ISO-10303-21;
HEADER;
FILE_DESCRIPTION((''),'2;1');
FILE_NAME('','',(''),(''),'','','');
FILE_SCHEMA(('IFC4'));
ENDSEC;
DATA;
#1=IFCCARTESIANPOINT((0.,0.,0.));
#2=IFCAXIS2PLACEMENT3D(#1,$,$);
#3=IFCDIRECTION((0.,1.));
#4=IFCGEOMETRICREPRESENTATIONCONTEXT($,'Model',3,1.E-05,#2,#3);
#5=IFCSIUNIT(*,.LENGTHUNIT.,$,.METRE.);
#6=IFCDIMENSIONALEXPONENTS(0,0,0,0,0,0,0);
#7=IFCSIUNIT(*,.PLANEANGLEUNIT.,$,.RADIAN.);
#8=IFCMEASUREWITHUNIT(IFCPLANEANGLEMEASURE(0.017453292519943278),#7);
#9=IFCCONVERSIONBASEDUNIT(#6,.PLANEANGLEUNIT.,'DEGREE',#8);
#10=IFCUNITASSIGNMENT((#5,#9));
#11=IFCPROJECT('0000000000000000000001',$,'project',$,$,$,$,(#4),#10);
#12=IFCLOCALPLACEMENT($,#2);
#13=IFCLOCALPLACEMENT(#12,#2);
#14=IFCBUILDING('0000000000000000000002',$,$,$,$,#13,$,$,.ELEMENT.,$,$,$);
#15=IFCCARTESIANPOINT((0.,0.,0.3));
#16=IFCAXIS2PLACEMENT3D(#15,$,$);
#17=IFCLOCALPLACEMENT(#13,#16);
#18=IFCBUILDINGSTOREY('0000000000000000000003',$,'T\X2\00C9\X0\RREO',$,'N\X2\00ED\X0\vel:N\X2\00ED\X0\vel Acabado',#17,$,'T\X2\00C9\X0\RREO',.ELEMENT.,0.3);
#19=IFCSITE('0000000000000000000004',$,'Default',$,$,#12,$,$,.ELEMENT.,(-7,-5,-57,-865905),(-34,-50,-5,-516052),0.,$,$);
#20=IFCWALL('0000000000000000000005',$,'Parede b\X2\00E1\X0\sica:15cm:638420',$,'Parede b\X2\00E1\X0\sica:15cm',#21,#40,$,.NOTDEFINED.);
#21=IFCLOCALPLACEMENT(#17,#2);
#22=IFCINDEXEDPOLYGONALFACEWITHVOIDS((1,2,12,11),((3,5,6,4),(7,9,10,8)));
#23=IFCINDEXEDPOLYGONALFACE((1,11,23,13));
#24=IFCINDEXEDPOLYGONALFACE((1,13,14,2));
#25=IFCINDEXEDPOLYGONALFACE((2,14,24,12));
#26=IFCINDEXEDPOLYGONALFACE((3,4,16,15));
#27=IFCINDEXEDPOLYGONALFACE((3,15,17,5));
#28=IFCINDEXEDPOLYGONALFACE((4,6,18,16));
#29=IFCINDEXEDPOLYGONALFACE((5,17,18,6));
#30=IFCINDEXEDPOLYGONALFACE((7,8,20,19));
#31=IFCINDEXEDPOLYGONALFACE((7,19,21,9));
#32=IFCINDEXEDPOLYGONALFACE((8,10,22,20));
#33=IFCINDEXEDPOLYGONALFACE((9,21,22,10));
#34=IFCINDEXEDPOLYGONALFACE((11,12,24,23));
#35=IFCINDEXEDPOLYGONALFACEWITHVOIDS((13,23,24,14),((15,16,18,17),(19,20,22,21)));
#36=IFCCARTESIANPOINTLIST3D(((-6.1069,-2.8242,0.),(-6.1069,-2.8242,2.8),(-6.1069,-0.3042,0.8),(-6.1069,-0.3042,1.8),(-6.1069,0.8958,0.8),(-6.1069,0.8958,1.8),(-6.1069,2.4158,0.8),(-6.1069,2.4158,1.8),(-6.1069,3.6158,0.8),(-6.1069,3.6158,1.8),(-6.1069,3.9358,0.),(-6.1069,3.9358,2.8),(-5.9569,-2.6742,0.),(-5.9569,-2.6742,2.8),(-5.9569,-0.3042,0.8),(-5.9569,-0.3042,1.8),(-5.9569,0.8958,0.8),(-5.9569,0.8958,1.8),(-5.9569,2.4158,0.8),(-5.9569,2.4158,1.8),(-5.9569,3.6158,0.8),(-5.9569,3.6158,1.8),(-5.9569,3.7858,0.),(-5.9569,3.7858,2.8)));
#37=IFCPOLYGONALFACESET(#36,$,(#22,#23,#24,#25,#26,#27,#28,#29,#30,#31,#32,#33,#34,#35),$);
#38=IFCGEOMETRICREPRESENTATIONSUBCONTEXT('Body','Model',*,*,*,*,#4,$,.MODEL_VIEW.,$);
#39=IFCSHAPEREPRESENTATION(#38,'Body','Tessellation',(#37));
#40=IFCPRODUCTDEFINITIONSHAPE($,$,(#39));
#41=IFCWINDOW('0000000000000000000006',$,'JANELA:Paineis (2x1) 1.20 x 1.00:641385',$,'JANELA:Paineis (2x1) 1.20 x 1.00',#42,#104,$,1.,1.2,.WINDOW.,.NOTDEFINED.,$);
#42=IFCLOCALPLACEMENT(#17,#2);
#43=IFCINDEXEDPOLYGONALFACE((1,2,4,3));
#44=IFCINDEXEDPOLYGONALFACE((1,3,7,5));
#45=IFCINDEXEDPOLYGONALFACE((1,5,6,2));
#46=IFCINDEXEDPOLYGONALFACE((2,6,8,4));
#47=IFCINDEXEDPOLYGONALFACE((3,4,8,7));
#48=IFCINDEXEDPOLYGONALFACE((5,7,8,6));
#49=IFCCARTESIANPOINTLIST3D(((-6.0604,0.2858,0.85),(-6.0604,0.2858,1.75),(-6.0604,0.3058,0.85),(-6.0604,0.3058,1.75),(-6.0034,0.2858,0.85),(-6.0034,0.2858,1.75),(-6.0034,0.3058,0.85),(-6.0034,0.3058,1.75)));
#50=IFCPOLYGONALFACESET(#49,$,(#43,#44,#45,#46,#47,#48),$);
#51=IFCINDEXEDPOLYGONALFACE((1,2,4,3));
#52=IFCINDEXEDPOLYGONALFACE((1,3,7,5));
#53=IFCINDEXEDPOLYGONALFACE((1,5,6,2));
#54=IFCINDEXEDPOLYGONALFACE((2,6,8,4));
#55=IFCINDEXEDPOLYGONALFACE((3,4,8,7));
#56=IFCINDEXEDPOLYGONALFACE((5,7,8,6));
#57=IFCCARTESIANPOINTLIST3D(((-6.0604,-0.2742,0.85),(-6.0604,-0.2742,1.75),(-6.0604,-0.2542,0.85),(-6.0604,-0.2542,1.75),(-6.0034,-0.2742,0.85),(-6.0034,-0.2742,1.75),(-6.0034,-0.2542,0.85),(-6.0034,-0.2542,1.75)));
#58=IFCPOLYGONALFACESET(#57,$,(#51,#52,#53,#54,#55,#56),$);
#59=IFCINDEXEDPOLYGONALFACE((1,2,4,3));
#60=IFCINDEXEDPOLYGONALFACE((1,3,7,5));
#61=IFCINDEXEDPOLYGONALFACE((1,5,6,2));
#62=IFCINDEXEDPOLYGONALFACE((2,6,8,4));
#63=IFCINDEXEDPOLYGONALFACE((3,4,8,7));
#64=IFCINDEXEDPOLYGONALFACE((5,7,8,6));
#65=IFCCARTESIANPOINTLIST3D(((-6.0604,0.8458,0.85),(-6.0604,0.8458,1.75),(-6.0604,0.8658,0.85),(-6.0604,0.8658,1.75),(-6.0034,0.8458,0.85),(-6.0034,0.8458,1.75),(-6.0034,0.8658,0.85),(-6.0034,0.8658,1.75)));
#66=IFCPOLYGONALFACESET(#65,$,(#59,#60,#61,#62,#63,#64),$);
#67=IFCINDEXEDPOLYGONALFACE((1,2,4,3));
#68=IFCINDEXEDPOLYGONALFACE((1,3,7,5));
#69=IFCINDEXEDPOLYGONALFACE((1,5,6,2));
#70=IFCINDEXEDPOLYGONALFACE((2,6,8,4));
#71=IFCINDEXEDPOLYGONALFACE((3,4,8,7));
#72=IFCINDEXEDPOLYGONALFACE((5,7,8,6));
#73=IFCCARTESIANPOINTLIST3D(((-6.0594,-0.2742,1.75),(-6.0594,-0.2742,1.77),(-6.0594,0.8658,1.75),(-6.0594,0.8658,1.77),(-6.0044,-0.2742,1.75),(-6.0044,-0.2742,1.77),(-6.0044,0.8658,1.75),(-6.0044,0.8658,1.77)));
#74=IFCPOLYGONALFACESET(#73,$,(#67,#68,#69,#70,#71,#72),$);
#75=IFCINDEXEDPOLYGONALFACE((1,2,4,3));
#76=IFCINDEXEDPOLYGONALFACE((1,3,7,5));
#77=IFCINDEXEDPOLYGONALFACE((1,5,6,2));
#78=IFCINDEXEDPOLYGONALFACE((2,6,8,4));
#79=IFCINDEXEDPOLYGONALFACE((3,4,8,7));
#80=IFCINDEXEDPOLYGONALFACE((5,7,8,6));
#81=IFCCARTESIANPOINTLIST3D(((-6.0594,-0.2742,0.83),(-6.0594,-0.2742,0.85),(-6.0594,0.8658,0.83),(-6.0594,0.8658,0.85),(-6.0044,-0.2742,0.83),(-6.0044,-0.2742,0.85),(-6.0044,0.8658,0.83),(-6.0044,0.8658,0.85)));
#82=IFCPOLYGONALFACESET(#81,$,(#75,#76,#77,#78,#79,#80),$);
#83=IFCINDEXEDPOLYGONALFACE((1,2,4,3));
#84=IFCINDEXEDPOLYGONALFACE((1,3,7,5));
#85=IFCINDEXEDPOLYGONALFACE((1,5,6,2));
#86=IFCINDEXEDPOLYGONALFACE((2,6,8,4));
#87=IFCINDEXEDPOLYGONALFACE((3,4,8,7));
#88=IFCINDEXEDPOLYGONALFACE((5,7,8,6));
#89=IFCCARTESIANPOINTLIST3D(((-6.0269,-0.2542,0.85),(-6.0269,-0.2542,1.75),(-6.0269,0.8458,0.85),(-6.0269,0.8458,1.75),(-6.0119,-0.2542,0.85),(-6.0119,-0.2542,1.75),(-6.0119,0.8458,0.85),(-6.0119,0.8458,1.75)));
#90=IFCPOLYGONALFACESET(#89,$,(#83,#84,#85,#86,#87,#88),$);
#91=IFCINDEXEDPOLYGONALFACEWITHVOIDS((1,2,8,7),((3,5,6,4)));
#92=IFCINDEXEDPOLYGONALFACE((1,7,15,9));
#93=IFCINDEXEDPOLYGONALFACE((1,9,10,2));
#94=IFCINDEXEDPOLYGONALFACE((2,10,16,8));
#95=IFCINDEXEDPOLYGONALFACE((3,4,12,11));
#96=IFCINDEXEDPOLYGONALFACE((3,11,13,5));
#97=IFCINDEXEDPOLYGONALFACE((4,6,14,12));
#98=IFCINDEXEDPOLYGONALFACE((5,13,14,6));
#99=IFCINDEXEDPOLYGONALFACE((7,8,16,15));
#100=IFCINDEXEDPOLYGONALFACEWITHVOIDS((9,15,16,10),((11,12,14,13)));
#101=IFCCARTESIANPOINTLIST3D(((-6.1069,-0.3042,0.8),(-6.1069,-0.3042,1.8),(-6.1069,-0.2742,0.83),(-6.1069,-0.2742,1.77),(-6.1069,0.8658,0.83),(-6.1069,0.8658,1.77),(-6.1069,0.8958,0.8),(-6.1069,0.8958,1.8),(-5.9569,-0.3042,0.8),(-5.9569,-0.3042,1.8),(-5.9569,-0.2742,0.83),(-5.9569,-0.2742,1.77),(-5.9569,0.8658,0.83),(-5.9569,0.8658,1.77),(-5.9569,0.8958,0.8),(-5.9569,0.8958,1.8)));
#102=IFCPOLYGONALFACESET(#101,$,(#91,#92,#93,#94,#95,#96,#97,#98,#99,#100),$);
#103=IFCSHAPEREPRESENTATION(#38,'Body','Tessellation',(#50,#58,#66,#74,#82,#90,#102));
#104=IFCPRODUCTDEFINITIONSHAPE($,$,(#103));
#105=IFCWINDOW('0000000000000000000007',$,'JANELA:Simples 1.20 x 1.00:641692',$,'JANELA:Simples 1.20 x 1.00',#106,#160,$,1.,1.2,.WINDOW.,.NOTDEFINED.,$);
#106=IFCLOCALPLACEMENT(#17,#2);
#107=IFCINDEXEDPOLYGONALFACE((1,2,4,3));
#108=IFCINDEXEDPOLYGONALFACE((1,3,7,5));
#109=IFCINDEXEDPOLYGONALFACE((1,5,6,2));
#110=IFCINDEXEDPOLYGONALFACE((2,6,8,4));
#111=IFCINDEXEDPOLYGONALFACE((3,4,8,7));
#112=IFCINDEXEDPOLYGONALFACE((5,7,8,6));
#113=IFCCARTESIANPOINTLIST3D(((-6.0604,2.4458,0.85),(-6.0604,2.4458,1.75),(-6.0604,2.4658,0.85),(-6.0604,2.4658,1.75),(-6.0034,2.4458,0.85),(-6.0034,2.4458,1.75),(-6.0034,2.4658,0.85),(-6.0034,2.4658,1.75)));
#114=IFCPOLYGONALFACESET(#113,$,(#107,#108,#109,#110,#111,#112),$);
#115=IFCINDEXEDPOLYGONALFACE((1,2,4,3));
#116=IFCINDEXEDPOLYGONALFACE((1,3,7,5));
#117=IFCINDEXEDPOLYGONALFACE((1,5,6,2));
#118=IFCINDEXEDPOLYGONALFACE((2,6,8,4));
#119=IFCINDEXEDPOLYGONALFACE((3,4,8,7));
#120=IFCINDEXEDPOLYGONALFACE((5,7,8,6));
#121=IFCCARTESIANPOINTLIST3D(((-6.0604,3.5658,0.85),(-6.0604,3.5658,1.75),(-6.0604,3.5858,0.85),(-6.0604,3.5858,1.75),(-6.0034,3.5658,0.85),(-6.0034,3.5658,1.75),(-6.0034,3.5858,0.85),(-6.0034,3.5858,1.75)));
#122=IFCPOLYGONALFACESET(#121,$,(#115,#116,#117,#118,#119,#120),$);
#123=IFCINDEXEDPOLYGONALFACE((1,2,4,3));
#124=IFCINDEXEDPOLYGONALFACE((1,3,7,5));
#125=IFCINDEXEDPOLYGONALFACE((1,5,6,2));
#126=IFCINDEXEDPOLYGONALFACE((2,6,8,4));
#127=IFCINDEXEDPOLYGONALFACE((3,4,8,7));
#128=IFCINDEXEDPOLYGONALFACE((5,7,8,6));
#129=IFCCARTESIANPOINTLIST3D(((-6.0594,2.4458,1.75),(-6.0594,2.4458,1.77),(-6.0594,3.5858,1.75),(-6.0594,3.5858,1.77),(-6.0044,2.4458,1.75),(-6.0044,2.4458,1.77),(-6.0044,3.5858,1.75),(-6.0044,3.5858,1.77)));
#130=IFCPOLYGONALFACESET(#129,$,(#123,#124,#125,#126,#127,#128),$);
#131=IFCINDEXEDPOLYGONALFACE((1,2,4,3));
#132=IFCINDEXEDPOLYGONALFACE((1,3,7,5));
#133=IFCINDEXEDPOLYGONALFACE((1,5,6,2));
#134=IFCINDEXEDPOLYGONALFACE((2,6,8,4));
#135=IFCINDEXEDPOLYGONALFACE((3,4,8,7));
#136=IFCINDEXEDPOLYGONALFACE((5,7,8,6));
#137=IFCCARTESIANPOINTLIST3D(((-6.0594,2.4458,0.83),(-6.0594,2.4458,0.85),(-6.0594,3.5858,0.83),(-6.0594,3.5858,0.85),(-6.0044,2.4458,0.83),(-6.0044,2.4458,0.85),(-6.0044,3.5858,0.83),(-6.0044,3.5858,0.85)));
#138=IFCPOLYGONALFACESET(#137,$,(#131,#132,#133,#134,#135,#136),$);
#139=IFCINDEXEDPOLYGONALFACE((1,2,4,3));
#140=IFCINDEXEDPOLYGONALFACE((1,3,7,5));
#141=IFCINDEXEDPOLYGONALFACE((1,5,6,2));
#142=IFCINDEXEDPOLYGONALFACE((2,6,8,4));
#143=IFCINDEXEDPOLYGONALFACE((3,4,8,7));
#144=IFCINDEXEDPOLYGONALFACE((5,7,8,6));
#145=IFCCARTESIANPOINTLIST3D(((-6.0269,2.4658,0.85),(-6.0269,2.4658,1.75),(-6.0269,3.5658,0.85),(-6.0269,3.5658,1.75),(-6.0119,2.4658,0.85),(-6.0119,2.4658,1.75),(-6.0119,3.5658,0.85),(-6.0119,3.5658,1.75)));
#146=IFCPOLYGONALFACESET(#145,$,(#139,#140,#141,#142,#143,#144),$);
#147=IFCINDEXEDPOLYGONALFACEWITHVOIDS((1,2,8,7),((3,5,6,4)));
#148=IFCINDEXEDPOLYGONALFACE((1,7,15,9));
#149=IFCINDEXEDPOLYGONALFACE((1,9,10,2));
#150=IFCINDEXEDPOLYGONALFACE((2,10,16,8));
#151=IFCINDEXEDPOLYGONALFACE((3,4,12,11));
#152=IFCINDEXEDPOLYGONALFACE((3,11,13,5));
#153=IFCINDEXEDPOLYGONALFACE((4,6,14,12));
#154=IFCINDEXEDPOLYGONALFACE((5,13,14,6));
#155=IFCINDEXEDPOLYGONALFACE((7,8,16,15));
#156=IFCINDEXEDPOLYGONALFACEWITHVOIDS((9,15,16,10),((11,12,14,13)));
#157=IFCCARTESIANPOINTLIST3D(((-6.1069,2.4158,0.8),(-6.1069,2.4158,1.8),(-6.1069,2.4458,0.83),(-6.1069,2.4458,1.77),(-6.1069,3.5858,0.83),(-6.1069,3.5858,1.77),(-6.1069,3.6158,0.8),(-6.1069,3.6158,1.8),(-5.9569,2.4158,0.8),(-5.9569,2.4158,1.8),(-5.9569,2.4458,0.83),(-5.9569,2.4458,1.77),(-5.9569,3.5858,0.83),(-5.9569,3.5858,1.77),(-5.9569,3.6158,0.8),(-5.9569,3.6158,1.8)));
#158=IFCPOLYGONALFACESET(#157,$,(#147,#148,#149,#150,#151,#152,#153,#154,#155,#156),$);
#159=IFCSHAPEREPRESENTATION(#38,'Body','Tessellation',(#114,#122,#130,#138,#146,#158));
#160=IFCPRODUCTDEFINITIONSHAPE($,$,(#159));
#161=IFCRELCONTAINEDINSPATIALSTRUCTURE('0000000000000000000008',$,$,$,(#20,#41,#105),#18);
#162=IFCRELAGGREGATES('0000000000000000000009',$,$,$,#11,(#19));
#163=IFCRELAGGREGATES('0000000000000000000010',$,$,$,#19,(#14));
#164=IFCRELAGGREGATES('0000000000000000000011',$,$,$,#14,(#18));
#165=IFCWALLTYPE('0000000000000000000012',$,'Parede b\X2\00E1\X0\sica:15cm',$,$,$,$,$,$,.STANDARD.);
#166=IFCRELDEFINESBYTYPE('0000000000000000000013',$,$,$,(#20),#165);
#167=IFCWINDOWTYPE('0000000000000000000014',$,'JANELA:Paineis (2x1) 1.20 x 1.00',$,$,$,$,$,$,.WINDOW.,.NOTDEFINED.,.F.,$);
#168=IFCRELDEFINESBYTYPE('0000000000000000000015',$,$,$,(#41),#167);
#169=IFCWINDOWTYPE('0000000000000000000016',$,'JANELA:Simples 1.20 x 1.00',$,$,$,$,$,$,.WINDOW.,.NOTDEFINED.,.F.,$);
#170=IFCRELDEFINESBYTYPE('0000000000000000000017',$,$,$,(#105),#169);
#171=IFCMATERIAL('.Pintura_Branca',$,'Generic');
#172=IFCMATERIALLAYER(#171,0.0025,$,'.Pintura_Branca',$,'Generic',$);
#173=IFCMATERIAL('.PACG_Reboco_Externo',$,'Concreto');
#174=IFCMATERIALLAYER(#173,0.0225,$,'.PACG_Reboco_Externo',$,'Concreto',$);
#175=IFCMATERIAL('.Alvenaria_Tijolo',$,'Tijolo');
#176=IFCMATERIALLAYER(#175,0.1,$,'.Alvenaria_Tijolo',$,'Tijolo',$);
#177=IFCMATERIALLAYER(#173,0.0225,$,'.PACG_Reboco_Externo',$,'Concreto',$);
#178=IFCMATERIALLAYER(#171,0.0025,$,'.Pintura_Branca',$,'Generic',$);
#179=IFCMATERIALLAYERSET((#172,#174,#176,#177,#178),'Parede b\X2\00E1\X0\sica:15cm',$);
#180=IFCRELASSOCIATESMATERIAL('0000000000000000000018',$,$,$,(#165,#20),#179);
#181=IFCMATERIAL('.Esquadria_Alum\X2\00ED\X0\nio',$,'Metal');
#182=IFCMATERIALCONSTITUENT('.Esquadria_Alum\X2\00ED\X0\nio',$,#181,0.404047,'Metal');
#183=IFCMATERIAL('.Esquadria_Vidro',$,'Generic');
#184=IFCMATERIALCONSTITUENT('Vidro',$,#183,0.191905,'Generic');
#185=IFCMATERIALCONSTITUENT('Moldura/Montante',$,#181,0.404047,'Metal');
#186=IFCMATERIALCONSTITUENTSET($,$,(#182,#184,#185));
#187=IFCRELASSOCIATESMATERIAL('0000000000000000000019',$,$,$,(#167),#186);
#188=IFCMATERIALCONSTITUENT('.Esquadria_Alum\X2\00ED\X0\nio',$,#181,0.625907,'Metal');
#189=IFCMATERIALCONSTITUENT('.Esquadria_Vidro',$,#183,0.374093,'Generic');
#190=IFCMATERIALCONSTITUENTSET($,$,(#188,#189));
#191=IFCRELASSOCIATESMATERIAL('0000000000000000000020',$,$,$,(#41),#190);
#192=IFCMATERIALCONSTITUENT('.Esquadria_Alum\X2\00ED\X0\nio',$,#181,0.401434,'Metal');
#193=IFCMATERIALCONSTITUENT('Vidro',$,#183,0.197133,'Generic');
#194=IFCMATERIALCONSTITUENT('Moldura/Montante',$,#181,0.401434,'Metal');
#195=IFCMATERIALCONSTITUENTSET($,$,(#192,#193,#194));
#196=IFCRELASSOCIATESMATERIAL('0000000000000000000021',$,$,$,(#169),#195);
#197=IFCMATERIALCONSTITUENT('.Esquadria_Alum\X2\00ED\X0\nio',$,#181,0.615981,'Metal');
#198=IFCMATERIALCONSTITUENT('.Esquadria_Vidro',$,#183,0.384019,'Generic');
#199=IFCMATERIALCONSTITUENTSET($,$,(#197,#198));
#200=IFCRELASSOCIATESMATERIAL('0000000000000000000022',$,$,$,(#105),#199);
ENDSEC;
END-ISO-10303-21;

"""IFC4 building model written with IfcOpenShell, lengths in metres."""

from ifc_helpers import new_model, entity, si_unit, converted_unit, direction, frame, frame_2d, origin, origin_2d_with_axis, place, context, subcontext, project, spatial, polyline, rectangle, outline, extrude, source, transform, mapped, material, layer, layer_set, layer_usage, constituent, constituent_set, type_object, type_shapes, element, fill, save


model = new_model("IFC4")

# Units and contexts
model_context = context("Model", 3, precision=1e-05, world=origin(), true_north=direction((0.0, 1.0)))
body_context = subcontext(model_context, "Body", "Model", "MODEL_VIEW")
ifc_project = project(units=[si_unit("LENGTHUNIT", "METRE"), converted_unit("PLANEANGLEUNIT", "DEGREE", entity("IfcPlaneAngleMeasure", 0.017453292519943278), si_unit("PLANEANGLEUNIT", "RADIAN"), dimensions=[0, 0, 0, 0, 0, 0, 0])], contexts=[model_context])

# Site, building, storey
site_placement = place(None, origin())
site = spatial("IfcSite", under=ifc_project, at=site_placement, Name="Default", CompositionType="ELEMENT", RefLatitude=(-7, -5, -57, -865905), RefLongitude=(-34, -50, -5, -516052), RefElevation=0.0)
building_placement = place(site_placement, origin())
building = spatial("IfcBuilding", under=site, at=building_placement, CompositionType="ELEMENT")
storey_placement = place(building_placement, frame((0.0, 0.0, 0.3)))
storey = spatial("IfcBuildingStorey", under=building, at=storey_placement, Name="TÉRREO", ObjectType="Nível:Nível Acabado", LongName="TÉRREO", CompositionType="ELEMENT", Elevation=0.3)

# Wall, openings, windows
ifc_material_1 = material(Name=".Pintura_Branca", Category="Generic")
ifc_layer_1 = layer(ifc_material_1, 0.0025, Name=".Pintura_Branca", Category="Generic")
ifc_material_2 = material(Name=".PACG_Reboco_Externo", Category="Concreto")
ifc_layer_2 = layer(ifc_material_2, 0.0225, Name=".PACG_Reboco_Externo", Category="Concreto")
ifc_material_3 = material(Name=".Alvenaria_Tijolo", Category="Tijolo")
ifc_layer_3 = layer(ifc_material_3, 0.1, Name=".Alvenaria_Tijolo", Category="Tijolo")
ifc_layer_4 = layer(ifc_material_2, 0.0225, Name=".PACG_Reboco_Externo", Category="Concreto")
ifc_layer_5 = layer(ifc_material_1, 0.0025, Name=".Pintura_Branca", Category="Generic")
ifc_layer_set_1 = layer_set([ifc_layer_1, ifc_layer_2, ifc_layer_3, ifc_layer_4, ifc_layer_5], Name="Parede básica:15cm")
ifc_layer_usage_1 = layer_usage(ifc_layer_set_1, "AXIS2", "NEGATIVE", 0.075)
wall_type = type_object("IfcWallType", Name="Parede básica:15cm", PredefinedType="STANDARD", material=ifc_layer_set_1)
wall_1_placement = place(storey_placement, frame((-6.0319, 3.9358, 0.0), z_axis=(0.0, 0.0, 1.0), x_axis=(0.0, -1.0, 0.0)))
wall_1 = element("IfcWall", 1, at=wall_1_placement, inside=storey, type_object=wall_type, material=ifc_layer_usage_1, Name="Parede básica:15cm:638420", ObjectType="Parede básica:15cm", PredefinedType="NOTDEFINED", context=body_context, shape_type="SweptSolid", body=[
    extrude(outline(polyline([(6.76, -0.075), (6.61, 0.075), (1.84, 0.075), (1.69, 0.075), (0.15, 0.075), (0.0, -0.075), (6.76, -0.075)])), origin(), (0.0, 0.0, 1.0), 2.8),
])
opening_1_placement = place(wall_1_placement, frame((4.24, 0.075, 0.8)))
opening_1 = element("IfcOpeningElement", 2, at=opening_1_placement, cuts=wall_1, PredefinedType="OPENING", context=body_context, shape_type="SweptSolid", body=[
    extrude(rectangle(XDim=1.0, YDim=1.2, at=frame_2d((0.5, 0.6), x_axis=(1.0, 0.0))), frame((0.0, 0.0, 0.0), z_axis=(0.0, -1.0, 0.0), x_axis=(0.0, 0.0, 1.0)), (0.0, 0.0, 1.0), 0.15),
])
opening_2_placement = place(wall_1_placement, frame((1.52, 0.075, 0.8)))
opening_2 = element("IfcOpeningElement", 3, at=opening_2_placement, cuts=wall_1, PredefinedType="OPENING", context=body_context, shape_type="SweptSolid", body=[
    extrude(rectangle(XDim=1.0, YDim=1.2, at=frame_2d((0.5, 0.6), x_axis=(1.0, 0.0))), frame((0.0, 0.0, 0.0), z_axis=(0.0, -1.0, 0.0), x_axis=(0.0, 0.0, 1.0)), (0.0, 0.0, 1.0), 0.15),
])
ifc_material_4 = material(Name=".Esquadria_Alumínio", Category="Metal")
ifc_constituent_1 = constituent(ifc_material_4, Name=".Esquadria_Alumínio", Category="Metal", fraction=0.625907)
ifc_material_5 = material(Name=".Esquadria_Vidro", Category="Generic")
ifc_constituent_2 = constituent(ifc_material_5, Name=".Esquadria_Vidro", Category="Generic", fraction=0.374093)
ifc_constituent_set_1 = constituent_set(constituents=[ifc_constituent_1, ifc_constituent_2])
ifc_constituent_3 = constituent(ifc_material_4, Name=".Esquadria_Alumínio", Category="Metal", fraction=0.404047)
ifc_constituent_4 = constituent(ifc_material_5, Name="Vidro", Category="Generic", fraction=0.191905)
ifc_constituent_5 = constituent(ifc_material_4, Name="Moldura/Montante", Category="Metal", fraction=0.404047)
ifc_constituent_set_2 = constituent_set(constituents=[ifc_constituent_3, ifc_constituent_4, ifc_constituent_5])
window_type_1 = type_object("IfcWindowType", Name="JANELA:Paineis (2x1) 1.20 x 1.00", ParameterTakesPrecedence=False, PartitioningType="NOTDEFINED", PredefinedType="WINDOW", material=ifc_constituent_set_2)
shared_shape_1 = source(origin(), body_context, "Body", "SweptSolid", [
    extrude(rectangle(XDim=0.02, YDim=0.057, at=origin_2d_with_axis()), frame((0.6, 0.075, 0.05), z_axis=(0.0, 0.0, 1.0), x_axis=(-1.0, 0.0, 0.0)), (0.0, 0.0, 1.0), 0.9),
    extrude(rectangle(XDim=0.02, YDim=0.057, at=frame_2d((0.0, 0.0), x_axis=(1.0, 0.0))), frame((0.04, 0.075, 0.05), z_axis=(0.0, 0.0, 1.0), x_axis=(-1.0, 0.0, 0.0)), (0.0, 0.0, 1.0), 0.9),
    extrude(rectangle(XDim=0.02, YDim=0.057, at=frame_2d((0.0, 0.0), x_axis=(1.0, 0.0))), frame((1.16, 0.075, 0.05), z_axis=(0.0, 0.0, 1.0), x_axis=(-1.0, 0.0, 0.0)), (0.0, 0.0, 1.0), 0.9),
    extrude(rectangle(XDim=1.14, YDim=0.055, at=frame_2d((0.0, 0.0), x_axis=(1.0, 0.0))), frame((0.6, 0.075, 0.95), z_axis=(0.0, 0.0, 1.0), x_axis=(-1.0, 0.0, 0.0)), (0.0, 0.0, 1.0), 0.02),
    extrude(rectangle(XDim=1.14, YDim=0.055, at=frame_2d((0.0, 0.0), x_axis=(1.0, 0.0))), frame((0.6, 0.075, 0.03), z_axis=(0.0, 0.0, 1.0), x_axis=(-1.0, 0.0, 0.0)), (0.0, 0.0, 1.0), 0.02),
    extrude(rectangle(XDim=0.015, YDim=1.1, at=frame_2d((0.0, 0.0), x_axis=(1.0, 0.0))), frame((0.6, 0.0625, 0.05), z_axis=(0.0, 0.0, 1.0), x_axis=(0.0, 1.0, 0.0)), (0.0, 0.0, 1.0), 0.9),
    extrude(outline(polyline([(-0.6, -0.5), (0.6, -0.5), (0.6, 0.5), (-0.6, 0.5), (-0.6, -0.5)]), holes=[polyline([(0.57, -0.47), (-0.57, -0.47), (-0.57, 0.47), (0.57, 0.47), (0.57, -0.47)])]), frame((0.6, 0.0, 0.5), z_axis=(0.0, 1.0, 0.0), x_axis=(1.0, 0.0, 0.0)), (0.0, 0.0, 1.0), 0.15),
])
type_shapes(window_type_1, [shared_shape_1])
window_1_placement = place(opening_1_placement, frame((0.0, 0.0, 0.0), z_axis=(0.0, 0.0, 1.0), x_axis=(-1.0, 0.0, 0.0)))
window_1 = element("IfcWindow", 4, at=window_1_placement, inside=storey, type_object=window_type_1, material=ifc_constituent_set_1, Name="JANELA:Paineis (2x1) 1.20 x 1.00:641385", ObjectType="JANELA:Paineis (2x1) 1.20 x 1.00", OverallHeight=1.0, OverallWidth=1.2, PartitioningType="NOTDEFINED", PredefinedType="WINDOW", context=body_context, shape_type="MappedRepresentation", body=[
    mapped(shared_shape_1, transform((0.0, 0.0, 0.0), scale=1.0)),
])
fill(opening_1, window_1)
ifc_constituent_6 = constituent(ifc_material_4, Name=".Esquadria_Alumínio", Category="Metal", fraction=0.615981)
ifc_constituent_7 = constituent(ifc_material_5, Name=".Esquadria_Vidro", Category="Generic", fraction=0.384019)
ifc_constituent_set_3 = constituent_set(constituents=[ifc_constituent_6, ifc_constituent_7])
ifc_constituent_8 = constituent(ifc_material_4, Name=".Esquadria_Alumínio", Category="Metal", fraction=0.401434)
ifc_constituent_9 = constituent(ifc_material_5, Name="Vidro", Category="Generic", fraction=0.197133)
ifc_constituent_10 = constituent(ifc_material_4, Name="Moldura/Montante", Category="Metal", fraction=0.401434)
ifc_constituent_set_4 = constituent_set(constituents=[ifc_constituent_8, ifc_constituent_9, ifc_constituent_10])
window_type_2 = type_object("IfcWindowType", Name="JANELA:Simples 1.20 x 1.00", ParameterTakesPrecedence=False, PartitioningType="NOTDEFINED", PredefinedType="WINDOW", material=ifc_constituent_set_4)
shared_shape_2 = source(origin(), body_context, "Body", "SweptSolid", [
    extrude(rectangle(XDim=0.02, YDim=0.057, at=frame_2d((0.0, 0.0), x_axis=(1.0, 0.0))), frame((0.04, 0.075, 0.05), z_axis=(0.0, 0.0, 1.0), x_axis=(-1.0, 0.0, 0.0)), (0.0, 0.0, 1.0), 0.9),
    extrude(rectangle(XDim=0.02, YDim=0.057, at=frame_2d((0.0, 0.0), x_axis=(1.0, 0.0))), frame((1.16, 0.075, 0.05), z_axis=(0.0, 0.0, 1.0), x_axis=(-1.0, 0.0, 0.0)), (0.0, 0.0, 1.0), 0.9),
    extrude(rectangle(XDim=1.14, YDim=0.055, at=frame_2d((0.0, 0.0), x_axis=(1.0, 0.0))), frame((0.6, 0.075, 0.95), z_axis=(0.0, 0.0, 1.0), x_axis=(-1.0, 0.0, 0.0)), (0.0, 0.0, 1.0), 0.02),
    extrude(rectangle(XDim=1.14, YDim=0.055, at=frame_2d((0.0, 0.0), x_axis=(1.0, 0.0))), frame((0.6, 0.075, 0.03), z_axis=(0.0, 0.0, 1.0), x_axis=(-1.0, 0.0, 0.0)), (0.0, 0.0, 1.0), 0.02),
    extrude(rectangle(XDim=0.015, YDim=1.1, at=frame_2d((0.0, 0.0), x_axis=(1.0, 0.0))), frame((0.6, 0.0625, 0.05), z_axis=(0.0, 0.0, 1.0), x_axis=(0.0, 1.0, 0.0)), (0.0, 0.0, 1.0), 0.9),
    extrude(outline(polyline([(-0.6, -0.5), (0.6, -0.5), (0.6, 0.5), (-0.6, 0.5), (-0.6, -0.5)]), holes=[polyline([(0.57, -0.47), (-0.57, -0.47), (-0.57, 0.47), (0.57, 0.47), (0.57, -0.47)])]), frame((0.6, 0.0, 0.5), z_axis=(0.0, 1.0, 0.0), x_axis=(1.0, 0.0, 0.0)), (0.0, 0.0, 1.0), 0.15),
])
type_shapes(window_type_2, [shared_shape_2])
window_2_placement = place(opening_2_placement, frame((0.0, 0.0, 0.0), z_axis=(0.0, 0.0, 1.0), x_axis=(-1.0, 0.0, 0.0)))
window_2 = element("IfcWindow", 5, at=window_2_placement, inside=storey, type_object=window_type_2, material=ifc_constituent_set_3, Name="JANELA:Simples 1.20 x 1.00:641692", ObjectType="JANELA:Simples 1.20 x 1.00", OverallHeight=1.0, OverallWidth=1.2, PartitioningType="NOTDEFINED", PredefinedType="WINDOW", context=body_context, shape_type="MappedRepresentation", body=[
    mapped(shared_shape_2, transform((0.0, 0.0, 0.0), scale=1.0)),
])
fill(opening_2, window_2)

save(model, "model.ifc")
